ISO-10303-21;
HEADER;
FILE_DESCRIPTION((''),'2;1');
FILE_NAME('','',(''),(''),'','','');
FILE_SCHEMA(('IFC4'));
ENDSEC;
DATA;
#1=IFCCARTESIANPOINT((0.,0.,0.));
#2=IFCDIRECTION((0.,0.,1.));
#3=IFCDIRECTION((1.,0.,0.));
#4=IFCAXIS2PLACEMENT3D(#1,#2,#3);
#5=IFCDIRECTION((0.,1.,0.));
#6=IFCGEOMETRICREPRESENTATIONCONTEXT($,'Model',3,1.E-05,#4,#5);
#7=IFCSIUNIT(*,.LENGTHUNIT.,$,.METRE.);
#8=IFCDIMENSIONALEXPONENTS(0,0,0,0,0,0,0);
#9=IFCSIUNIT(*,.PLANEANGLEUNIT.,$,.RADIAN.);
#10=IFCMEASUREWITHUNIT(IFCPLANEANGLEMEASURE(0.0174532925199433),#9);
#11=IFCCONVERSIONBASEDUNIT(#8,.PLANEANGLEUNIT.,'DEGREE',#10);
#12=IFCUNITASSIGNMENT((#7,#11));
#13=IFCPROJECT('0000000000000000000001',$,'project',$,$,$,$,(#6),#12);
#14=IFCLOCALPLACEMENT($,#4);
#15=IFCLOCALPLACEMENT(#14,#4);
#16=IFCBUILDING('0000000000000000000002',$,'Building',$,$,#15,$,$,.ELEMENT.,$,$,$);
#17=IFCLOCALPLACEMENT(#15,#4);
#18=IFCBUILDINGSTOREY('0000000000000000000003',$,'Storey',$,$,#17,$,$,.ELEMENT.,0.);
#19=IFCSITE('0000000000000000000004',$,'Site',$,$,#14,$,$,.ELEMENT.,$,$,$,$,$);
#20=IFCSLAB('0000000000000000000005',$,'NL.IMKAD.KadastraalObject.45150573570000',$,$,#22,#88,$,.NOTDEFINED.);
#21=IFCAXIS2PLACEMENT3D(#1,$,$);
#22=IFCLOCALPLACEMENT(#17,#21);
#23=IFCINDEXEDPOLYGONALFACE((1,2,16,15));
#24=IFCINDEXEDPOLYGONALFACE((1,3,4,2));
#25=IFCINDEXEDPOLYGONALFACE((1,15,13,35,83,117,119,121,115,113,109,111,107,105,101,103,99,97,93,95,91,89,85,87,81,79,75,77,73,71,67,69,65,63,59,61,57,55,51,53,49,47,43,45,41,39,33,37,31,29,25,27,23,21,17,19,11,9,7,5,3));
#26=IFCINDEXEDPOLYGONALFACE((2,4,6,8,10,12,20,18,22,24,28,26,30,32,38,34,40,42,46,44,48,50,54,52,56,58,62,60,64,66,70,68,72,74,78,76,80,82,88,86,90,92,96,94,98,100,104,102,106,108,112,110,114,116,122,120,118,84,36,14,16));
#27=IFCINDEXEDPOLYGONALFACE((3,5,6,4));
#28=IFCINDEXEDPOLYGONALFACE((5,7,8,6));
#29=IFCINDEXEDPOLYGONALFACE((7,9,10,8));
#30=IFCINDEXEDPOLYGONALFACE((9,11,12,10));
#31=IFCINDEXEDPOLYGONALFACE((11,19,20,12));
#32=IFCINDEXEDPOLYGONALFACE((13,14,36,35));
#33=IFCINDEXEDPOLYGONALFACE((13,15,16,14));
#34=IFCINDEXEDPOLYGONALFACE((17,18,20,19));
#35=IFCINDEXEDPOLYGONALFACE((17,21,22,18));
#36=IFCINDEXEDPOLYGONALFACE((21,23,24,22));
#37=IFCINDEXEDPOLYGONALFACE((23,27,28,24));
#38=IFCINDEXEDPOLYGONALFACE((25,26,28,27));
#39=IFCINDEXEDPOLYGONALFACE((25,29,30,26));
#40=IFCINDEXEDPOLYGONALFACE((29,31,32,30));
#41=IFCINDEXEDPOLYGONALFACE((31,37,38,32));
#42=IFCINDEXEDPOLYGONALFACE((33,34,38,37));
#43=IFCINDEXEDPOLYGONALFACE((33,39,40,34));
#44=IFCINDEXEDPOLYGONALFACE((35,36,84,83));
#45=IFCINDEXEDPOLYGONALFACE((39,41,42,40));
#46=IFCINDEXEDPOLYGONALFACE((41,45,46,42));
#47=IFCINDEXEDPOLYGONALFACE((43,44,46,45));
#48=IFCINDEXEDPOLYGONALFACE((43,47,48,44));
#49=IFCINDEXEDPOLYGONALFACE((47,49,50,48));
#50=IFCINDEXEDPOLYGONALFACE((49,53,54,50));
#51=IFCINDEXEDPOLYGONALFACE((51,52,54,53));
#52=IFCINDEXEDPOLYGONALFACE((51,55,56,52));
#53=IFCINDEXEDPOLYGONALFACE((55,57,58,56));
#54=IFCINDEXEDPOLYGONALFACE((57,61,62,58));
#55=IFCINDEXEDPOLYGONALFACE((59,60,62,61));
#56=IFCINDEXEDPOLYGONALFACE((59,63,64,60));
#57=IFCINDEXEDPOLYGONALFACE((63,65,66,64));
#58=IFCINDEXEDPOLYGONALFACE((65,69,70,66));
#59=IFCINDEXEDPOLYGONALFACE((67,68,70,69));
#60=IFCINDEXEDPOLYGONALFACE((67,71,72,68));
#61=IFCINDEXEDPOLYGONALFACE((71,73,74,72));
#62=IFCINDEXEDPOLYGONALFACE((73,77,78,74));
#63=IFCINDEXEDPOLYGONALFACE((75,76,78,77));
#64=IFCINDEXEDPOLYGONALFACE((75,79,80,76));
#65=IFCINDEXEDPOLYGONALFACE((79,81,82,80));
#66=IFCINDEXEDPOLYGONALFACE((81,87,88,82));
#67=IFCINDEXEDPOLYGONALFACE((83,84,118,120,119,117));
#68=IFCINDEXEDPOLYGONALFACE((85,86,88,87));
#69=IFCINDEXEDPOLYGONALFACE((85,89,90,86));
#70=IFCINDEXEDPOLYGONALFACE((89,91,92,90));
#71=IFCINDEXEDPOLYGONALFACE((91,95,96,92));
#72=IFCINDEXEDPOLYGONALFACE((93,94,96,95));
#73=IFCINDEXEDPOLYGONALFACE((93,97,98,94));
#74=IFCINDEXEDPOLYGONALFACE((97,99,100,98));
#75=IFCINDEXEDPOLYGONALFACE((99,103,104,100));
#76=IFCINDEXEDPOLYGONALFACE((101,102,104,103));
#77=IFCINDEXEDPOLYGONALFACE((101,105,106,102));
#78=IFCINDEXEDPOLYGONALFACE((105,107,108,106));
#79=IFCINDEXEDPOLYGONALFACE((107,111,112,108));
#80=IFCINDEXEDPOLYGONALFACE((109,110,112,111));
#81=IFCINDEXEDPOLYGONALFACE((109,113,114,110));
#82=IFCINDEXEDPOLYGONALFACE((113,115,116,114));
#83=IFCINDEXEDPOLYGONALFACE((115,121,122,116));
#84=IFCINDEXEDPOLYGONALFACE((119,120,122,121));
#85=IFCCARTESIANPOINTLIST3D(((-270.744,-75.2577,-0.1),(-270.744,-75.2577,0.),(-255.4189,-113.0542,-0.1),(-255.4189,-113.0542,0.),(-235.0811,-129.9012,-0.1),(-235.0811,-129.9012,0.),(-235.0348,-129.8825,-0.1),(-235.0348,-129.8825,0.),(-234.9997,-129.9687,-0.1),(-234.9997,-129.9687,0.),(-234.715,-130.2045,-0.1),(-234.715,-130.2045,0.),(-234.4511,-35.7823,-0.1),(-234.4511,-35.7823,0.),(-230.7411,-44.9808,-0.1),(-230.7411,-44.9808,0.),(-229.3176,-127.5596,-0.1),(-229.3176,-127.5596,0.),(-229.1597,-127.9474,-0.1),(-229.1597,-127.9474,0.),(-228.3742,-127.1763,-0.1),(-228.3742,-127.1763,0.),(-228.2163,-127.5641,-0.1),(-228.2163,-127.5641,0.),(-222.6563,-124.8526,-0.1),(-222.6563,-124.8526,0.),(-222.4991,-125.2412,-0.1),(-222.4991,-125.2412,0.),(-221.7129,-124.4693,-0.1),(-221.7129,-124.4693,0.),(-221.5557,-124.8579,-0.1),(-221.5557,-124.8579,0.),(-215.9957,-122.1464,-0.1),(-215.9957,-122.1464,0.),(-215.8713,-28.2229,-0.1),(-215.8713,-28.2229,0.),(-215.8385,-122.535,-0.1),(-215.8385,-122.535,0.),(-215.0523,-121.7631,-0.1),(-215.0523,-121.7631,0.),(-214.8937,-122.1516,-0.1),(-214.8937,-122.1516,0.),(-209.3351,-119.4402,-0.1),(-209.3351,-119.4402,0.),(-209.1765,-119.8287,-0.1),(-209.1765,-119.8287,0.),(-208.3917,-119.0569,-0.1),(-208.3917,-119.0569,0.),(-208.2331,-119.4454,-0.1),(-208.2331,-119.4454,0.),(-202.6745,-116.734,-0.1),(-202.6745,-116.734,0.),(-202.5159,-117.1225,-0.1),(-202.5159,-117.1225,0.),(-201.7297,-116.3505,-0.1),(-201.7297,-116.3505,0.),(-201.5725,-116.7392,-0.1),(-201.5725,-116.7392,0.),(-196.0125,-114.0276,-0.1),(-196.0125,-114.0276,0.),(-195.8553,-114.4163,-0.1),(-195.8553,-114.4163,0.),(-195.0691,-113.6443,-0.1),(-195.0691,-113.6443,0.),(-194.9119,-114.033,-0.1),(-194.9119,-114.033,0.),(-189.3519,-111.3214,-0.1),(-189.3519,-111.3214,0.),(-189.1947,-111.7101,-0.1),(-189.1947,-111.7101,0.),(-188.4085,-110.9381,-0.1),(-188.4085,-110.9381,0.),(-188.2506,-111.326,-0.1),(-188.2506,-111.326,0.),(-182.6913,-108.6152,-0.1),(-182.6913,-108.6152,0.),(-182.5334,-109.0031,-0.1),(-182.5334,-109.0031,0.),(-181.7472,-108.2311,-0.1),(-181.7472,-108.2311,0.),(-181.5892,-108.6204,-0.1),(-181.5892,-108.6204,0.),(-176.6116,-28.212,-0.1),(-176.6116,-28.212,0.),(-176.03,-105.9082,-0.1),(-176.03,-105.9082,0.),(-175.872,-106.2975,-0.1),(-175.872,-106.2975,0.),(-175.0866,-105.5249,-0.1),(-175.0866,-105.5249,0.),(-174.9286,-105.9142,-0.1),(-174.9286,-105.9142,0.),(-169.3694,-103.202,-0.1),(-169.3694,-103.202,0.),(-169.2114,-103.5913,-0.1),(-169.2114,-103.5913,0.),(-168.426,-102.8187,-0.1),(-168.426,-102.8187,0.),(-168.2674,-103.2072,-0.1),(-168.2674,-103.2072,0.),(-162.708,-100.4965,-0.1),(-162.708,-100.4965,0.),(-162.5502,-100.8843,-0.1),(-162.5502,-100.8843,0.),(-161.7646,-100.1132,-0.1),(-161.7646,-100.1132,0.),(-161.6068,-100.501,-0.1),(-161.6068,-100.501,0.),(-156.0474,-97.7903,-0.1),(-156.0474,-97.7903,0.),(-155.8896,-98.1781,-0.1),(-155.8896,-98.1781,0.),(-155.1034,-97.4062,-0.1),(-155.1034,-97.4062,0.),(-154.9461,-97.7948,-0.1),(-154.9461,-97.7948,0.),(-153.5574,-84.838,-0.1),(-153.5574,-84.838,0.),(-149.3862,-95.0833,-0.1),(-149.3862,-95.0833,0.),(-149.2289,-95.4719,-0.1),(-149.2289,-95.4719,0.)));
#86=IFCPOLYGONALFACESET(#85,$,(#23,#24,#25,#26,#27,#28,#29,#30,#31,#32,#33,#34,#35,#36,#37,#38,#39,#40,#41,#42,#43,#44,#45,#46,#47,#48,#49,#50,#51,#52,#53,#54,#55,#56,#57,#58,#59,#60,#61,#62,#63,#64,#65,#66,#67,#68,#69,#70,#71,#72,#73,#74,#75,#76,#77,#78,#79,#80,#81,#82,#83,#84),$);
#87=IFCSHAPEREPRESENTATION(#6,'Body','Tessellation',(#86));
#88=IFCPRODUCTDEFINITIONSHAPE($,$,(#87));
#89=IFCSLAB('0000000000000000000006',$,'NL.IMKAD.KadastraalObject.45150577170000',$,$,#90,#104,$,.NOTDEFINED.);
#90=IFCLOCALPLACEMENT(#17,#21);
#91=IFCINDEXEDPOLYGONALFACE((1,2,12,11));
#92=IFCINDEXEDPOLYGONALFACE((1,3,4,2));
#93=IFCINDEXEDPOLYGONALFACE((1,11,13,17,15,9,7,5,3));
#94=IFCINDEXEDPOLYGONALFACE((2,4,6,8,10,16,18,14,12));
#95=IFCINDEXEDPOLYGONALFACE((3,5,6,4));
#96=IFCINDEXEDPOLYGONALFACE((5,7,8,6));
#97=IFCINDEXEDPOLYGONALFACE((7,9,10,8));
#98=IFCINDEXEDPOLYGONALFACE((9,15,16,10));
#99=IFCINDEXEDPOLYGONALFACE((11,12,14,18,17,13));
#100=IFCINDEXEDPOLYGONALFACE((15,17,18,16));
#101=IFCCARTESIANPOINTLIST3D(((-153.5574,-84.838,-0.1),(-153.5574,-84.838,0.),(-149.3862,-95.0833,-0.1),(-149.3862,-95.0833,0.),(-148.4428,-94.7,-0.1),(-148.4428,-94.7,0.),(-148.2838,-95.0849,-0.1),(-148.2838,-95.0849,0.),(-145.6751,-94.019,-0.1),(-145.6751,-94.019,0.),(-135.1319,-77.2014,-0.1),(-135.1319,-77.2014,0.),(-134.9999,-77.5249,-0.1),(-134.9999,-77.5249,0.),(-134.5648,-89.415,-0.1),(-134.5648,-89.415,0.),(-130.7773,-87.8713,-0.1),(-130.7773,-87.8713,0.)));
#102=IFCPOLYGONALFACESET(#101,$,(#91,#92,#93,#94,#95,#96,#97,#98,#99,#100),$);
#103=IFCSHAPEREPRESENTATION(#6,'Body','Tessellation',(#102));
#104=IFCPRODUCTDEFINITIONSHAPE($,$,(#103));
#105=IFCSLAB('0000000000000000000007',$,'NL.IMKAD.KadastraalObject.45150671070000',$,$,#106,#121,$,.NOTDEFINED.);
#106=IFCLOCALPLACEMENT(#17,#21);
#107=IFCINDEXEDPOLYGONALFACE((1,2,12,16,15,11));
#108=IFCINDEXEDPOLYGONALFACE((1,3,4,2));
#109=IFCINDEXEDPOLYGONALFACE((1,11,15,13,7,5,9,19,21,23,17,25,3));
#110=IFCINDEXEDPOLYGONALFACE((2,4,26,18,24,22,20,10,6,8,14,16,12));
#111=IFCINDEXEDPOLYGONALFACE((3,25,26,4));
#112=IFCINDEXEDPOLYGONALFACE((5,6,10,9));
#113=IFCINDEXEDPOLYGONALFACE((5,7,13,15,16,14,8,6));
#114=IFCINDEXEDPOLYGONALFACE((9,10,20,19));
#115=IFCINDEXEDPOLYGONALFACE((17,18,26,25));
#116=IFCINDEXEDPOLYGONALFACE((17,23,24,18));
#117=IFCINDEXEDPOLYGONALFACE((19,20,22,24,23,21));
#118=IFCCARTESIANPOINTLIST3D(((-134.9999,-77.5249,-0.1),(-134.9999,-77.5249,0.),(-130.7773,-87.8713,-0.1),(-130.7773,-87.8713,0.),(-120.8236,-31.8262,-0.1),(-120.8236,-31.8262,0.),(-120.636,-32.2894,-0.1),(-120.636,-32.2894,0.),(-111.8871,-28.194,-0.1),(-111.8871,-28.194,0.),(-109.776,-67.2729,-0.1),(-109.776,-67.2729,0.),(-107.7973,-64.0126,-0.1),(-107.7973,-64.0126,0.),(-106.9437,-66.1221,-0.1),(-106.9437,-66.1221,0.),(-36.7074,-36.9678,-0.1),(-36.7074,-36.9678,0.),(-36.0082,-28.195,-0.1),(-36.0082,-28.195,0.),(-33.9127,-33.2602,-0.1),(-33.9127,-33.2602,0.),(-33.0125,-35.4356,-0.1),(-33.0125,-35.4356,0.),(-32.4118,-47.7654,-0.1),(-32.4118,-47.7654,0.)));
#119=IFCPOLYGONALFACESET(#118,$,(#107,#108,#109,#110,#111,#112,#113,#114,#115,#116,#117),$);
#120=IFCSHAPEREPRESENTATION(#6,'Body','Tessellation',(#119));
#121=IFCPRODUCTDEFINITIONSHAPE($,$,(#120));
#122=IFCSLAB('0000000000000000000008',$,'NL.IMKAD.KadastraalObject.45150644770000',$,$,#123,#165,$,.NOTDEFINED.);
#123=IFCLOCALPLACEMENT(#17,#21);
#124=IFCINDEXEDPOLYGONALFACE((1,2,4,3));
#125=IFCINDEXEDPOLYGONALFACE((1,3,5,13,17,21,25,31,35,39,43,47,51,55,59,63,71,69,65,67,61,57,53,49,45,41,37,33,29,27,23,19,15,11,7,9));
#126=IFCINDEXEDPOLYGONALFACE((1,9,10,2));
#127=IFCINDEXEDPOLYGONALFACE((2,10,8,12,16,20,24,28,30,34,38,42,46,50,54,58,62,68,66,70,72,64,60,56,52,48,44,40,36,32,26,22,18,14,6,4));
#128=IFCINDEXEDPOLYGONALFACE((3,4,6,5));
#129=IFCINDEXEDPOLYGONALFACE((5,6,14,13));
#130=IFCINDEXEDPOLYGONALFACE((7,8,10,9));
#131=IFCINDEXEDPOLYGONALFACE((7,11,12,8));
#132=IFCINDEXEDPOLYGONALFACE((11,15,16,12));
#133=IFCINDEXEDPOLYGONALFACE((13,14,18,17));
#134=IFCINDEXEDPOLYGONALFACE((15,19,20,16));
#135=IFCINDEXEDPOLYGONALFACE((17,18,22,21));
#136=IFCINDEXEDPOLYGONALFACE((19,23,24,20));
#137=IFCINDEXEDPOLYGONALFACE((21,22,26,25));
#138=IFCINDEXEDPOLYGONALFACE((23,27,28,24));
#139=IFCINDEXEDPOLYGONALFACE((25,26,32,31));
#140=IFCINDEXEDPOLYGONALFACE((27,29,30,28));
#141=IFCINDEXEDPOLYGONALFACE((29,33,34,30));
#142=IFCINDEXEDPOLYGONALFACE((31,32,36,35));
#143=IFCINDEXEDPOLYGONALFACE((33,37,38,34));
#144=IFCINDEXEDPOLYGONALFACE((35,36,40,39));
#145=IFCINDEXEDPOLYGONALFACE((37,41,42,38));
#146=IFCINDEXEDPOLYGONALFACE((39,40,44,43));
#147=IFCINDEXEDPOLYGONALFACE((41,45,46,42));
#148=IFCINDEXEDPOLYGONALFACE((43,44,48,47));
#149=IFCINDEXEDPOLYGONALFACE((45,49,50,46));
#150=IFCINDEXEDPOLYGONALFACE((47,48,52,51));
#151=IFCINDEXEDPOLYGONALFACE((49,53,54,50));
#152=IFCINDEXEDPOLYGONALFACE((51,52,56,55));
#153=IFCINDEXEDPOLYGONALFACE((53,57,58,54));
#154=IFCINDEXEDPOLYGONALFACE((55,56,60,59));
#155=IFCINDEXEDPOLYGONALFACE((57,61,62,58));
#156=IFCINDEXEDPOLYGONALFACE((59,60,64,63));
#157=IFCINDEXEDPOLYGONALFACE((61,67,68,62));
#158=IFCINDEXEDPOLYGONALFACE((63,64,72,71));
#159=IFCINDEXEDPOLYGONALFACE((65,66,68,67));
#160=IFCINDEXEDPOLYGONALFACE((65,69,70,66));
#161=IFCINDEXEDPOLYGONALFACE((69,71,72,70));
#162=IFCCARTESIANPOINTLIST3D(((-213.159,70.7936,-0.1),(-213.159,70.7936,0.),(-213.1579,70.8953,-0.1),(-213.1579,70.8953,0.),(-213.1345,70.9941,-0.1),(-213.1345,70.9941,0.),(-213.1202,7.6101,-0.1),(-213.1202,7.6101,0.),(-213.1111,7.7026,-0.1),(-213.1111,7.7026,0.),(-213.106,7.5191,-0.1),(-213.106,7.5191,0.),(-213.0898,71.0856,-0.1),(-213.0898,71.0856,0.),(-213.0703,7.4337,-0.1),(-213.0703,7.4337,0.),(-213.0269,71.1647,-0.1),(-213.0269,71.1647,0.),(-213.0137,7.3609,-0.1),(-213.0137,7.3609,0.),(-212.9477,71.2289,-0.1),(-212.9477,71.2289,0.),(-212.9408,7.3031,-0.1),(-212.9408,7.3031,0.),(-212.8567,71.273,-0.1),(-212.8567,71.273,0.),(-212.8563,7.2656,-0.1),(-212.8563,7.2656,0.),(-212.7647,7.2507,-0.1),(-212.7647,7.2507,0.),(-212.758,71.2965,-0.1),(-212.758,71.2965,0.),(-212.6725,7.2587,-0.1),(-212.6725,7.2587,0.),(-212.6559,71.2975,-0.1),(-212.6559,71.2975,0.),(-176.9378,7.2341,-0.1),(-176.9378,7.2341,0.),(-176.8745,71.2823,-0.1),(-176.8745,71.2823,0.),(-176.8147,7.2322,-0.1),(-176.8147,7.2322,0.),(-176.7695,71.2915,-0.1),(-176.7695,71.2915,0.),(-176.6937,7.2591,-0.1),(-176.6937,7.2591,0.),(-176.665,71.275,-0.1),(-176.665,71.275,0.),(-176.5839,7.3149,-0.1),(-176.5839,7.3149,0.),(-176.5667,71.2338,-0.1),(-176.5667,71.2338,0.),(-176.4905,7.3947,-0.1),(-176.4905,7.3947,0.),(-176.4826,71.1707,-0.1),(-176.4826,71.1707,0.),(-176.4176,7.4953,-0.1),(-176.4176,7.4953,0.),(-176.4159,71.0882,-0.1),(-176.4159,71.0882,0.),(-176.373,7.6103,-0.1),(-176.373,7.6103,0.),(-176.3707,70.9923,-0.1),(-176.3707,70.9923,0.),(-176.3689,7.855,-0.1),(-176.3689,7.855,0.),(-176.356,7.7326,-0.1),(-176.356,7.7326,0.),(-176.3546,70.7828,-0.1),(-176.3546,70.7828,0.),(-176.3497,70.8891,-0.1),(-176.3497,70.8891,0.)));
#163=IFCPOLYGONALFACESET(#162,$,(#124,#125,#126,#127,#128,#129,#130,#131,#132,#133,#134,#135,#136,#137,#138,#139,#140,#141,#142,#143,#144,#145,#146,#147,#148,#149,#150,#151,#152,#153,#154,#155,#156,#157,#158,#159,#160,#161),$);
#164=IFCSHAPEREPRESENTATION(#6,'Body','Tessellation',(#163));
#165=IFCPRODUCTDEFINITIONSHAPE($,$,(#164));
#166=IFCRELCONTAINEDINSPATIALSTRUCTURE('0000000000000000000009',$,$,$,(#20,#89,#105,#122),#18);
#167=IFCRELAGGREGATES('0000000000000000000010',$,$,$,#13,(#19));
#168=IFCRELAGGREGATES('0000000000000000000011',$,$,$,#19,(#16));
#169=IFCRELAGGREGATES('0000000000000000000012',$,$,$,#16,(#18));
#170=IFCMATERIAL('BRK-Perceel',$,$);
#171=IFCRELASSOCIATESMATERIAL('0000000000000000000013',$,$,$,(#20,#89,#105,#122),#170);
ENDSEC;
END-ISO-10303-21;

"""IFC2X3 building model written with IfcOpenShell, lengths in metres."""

from ifc_helpers import new_model, entity, si_unit, converted_unit, direction, frame, origin_with_axes, place, context, project, spatial, polyline, outline, extrude, material, element, save


model = new_model("IFC2X3")

# Units and contexts
model_context = context("Model", 3, precision=1e-05, world=origin_with_axes(), true_north=direction((0.0, 1.0, 0.0)))
ifc_project = project(units=[si_unit("LENGTHUNIT", "METRE"), converted_unit("PLANEANGLEUNIT", "DEGREE", entity("IfcPlaneAngleMeasure", 0.0174532925199433), si_unit("PLANEANGLEUNIT", "RADIAN"), dimensions=[0, 0, 0, 0, 0, 0, 0])], contexts=[model_context])

# Site, building, storey
site_placement = place(None, origin_with_axes())
site = spatial("IfcSite", under=ifc_project, at=site_placement, Name="Site", CompositionType="ELEMENT")
building_placement = place(site_placement, origin_with_axes())
building = spatial("IfcBuilding", under=site, at=building_placement, Name="Building", CompositionType="ELEMENT")
storey_placement = place(building_placement, origin_with_axes())
storey = spatial("IfcBuildingStorey", under=building, at=storey_placement, Name="Storey", CompositionType="ELEMENT", Elevation=0.0)

# Slabs
ifc_material = material(Name="BRK-Perceel")
slab_1_placement = place(storey_placement, frame((0.0, 0.0, -0.1), z_axis=(0.0, 0.0, 1.0), x_axis=(1.0, 0.0, 0.0)))
element("IfcSlab", 1, at=slab_1_placement, inside=storey, material=ifc_material, Name="NL.IMKAD.KadastraalObject.45150573570000", PredefinedType="NOTDEFINED", context=model_context, shape_type="SweptSolid", body=[
    extrude(outline(polyline([(-270.744, -75.2577), (-230.7411, -44.9808), (-234.4511, -35.7823), (-215.8713, -28.2229), (-176.6116, -28.212), (-153.5574, -84.838), (-149.3862, -95.0833), (-149.2289, -95.4719), (-154.9461, -97.7948), (-155.1034, -97.4062), (-156.0474, -97.7903), (-155.8896, -98.1781), (-161.6068, -100.501), (-161.7646, -100.1132), (-162.708, -100.4965), (-162.5502, -100.8843), (-168.2674, -103.2072), (-168.426, -102.8187), (-169.3694, -103.202), (-169.2114, -103.5913), (-174.9286, -105.9142), (-175.0866, -105.5249), (-176.03, -105.9082), (-175.872, -106.2975), (-181.5892, -108.6204), (-181.7472, -108.2311), (-182.6913, -108.6152), (-182.5334, -109.0031), (-188.2506, -111.326), (-188.4085, -110.9381), (-189.3519, -111.3214), (-189.1947, -111.7101), (-194.9119, -114.033), (-195.0691, -113.6443), (-196.0125, -114.0276), (-195.8553, -114.4163), (-201.5725, -116.7392), (-201.7297, -116.3505), (-202.6745, -116.734), (-202.5159, -117.1225), (-208.2331, -119.4454), (-208.3917, -119.0569), (-209.3351, -119.4402), (-209.1765, -119.8287), (-214.8937, -122.1516), (-215.0523, -121.7631), (-215.9957, -122.1464), (-215.8385, -122.535), (-221.5557, -124.8579), (-221.7129, -124.4693), (-222.6563, -124.8526), (-222.4991, -125.2412), (-228.2163, -127.5641), (-228.3742, -127.1763), (-229.3176, -127.5596), (-229.1597, -127.9474), (-234.715, -130.2045), (-234.9997, -129.9687), (-235.0348, -129.8825), (-235.0811, -129.9012), (-255.4189, -113.0542), (-270.744, -75.2577)])), origin_with_axes(), (0.0, 0.0, 1.0), 0.1),
])
slab_2_placement = place(storey_placement, frame((0.0, 0.0, -0.1), z_axis=(0.0, 0.0, 1.0), x_axis=(1.0, 0.0, 0.0)))
element("IfcSlab", 2, at=slab_2_placement, inside=storey, material=ifc_material, Name="NL.IMKAD.KadastraalObject.45150577170000", PredefinedType="NOTDEFINED", context=model_context, shape_type="SweptSolid", body=[
    extrude(outline(polyline([(-130.7773, -87.8713), (-134.5648, -89.415), (-145.6751, -94.019), (-148.2838, -95.0849), (-148.4428, -94.7), (-149.3862, -95.0833), (-153.5574, -84.838), (-135.1319, -77.2014), (-134.9999, -77.5249), (-130.7773, -87.8713)])), origin_with_axes(), (0.0, 0.0, 1.0), 0.1),
])
slab_3_placement = place(storey_placement, frame((0.0, 0.0, -0.1), z_axis=(0.0, 0.0, 1.0), x_axis=(1.0, 0.0, 0.0)))
element("IfcSlab", 3, at=slab_3_placement, inside=storey, material=ifc_material, Name="NL.IMKAD.KadastraalObject.45150671070000", PredefinedType="NOTDEFINED", context=model_context, shape_type="SweptSolid", body=[
    extrude(outline(polyline([(-107.7973, -64.0126), (-120.636, -32.2894), (-120.8236, -31.8262), (-111.8871, -28.194), (-36.0082, -28.195), (-33.9127, -33.2602), (-33.0125, -35.4356), (-36.7074, -36.9678), (-32.4118, -47.7654), (-130.7773, -87.8713), (-134.9999, -77.5249), (-109.776, -67.2729), (-106.9437, -66.1221), (-107.7973, -64.0126)])), origin_with_axes(), (0.0, 0.0, 1.0), 0.1),
])
slab_4_placement = place(storey_placement, frame((0.0, 0.0, -0.1), z_axis=(0.0, 0.0, 1.0), x_axis=(1.0, 0.0, 0.0)))
element("IfcSlab", 4, at=slab_4_placement, inside=storey, material=ifc_material, Name="NL.IMKAD.KadastraalObject.45150644770000", PredefinedType="NOTDEFINED", context=model_context, shape_type="SweptSolid", body=[
    extrude(outline(polyline([(-176.3689, 7.855), (-176.356, 7.7326), (-176.373, 7.6103), (-176.4176, 7.4953), (-176.4905, 7.3947), (-176.5839, 7.3149), (-176.6937, 7.2591), (-176.8147, 7.2322), (-176.9378, 7.2341), (-212.6725, 7.2587), (-212.7647, 7.2507), (-212.8563, 7.2656), (-212.9408, 7.3031), (-213.0137, 7.3609), (-213.0703, 7.4337), (-213.106, 7.5191), (-213.1202, 7.6101), (-213.1111, 7.7026), (-213.159, 70.7936), (-213.1579, 70.8953), (-213.1345, 70.9941), (-213.0898, 71.0856), (-213.0269, 71.1647), (-212.9477, 71.2289), (-212.8567, 71.273), (-212.758, 71.2965), (-212.6559, 71.2975), (-176.8745, 71.2823), (-176.7695, 71.2915), (-176.665, 71.275), (-176.5667, 71.2338), (-176.4826, 71.1707), (-176.4159, 71.0882), (-176.3707, 70.9923), (-176.3497, 70.8891), (-176.3546, 70.7828), (-176.3689, 7.855)])), origin_with_axes(), (0.0, 0.0, 1.0), 0.1),
])

save(model, "model.ifc")
